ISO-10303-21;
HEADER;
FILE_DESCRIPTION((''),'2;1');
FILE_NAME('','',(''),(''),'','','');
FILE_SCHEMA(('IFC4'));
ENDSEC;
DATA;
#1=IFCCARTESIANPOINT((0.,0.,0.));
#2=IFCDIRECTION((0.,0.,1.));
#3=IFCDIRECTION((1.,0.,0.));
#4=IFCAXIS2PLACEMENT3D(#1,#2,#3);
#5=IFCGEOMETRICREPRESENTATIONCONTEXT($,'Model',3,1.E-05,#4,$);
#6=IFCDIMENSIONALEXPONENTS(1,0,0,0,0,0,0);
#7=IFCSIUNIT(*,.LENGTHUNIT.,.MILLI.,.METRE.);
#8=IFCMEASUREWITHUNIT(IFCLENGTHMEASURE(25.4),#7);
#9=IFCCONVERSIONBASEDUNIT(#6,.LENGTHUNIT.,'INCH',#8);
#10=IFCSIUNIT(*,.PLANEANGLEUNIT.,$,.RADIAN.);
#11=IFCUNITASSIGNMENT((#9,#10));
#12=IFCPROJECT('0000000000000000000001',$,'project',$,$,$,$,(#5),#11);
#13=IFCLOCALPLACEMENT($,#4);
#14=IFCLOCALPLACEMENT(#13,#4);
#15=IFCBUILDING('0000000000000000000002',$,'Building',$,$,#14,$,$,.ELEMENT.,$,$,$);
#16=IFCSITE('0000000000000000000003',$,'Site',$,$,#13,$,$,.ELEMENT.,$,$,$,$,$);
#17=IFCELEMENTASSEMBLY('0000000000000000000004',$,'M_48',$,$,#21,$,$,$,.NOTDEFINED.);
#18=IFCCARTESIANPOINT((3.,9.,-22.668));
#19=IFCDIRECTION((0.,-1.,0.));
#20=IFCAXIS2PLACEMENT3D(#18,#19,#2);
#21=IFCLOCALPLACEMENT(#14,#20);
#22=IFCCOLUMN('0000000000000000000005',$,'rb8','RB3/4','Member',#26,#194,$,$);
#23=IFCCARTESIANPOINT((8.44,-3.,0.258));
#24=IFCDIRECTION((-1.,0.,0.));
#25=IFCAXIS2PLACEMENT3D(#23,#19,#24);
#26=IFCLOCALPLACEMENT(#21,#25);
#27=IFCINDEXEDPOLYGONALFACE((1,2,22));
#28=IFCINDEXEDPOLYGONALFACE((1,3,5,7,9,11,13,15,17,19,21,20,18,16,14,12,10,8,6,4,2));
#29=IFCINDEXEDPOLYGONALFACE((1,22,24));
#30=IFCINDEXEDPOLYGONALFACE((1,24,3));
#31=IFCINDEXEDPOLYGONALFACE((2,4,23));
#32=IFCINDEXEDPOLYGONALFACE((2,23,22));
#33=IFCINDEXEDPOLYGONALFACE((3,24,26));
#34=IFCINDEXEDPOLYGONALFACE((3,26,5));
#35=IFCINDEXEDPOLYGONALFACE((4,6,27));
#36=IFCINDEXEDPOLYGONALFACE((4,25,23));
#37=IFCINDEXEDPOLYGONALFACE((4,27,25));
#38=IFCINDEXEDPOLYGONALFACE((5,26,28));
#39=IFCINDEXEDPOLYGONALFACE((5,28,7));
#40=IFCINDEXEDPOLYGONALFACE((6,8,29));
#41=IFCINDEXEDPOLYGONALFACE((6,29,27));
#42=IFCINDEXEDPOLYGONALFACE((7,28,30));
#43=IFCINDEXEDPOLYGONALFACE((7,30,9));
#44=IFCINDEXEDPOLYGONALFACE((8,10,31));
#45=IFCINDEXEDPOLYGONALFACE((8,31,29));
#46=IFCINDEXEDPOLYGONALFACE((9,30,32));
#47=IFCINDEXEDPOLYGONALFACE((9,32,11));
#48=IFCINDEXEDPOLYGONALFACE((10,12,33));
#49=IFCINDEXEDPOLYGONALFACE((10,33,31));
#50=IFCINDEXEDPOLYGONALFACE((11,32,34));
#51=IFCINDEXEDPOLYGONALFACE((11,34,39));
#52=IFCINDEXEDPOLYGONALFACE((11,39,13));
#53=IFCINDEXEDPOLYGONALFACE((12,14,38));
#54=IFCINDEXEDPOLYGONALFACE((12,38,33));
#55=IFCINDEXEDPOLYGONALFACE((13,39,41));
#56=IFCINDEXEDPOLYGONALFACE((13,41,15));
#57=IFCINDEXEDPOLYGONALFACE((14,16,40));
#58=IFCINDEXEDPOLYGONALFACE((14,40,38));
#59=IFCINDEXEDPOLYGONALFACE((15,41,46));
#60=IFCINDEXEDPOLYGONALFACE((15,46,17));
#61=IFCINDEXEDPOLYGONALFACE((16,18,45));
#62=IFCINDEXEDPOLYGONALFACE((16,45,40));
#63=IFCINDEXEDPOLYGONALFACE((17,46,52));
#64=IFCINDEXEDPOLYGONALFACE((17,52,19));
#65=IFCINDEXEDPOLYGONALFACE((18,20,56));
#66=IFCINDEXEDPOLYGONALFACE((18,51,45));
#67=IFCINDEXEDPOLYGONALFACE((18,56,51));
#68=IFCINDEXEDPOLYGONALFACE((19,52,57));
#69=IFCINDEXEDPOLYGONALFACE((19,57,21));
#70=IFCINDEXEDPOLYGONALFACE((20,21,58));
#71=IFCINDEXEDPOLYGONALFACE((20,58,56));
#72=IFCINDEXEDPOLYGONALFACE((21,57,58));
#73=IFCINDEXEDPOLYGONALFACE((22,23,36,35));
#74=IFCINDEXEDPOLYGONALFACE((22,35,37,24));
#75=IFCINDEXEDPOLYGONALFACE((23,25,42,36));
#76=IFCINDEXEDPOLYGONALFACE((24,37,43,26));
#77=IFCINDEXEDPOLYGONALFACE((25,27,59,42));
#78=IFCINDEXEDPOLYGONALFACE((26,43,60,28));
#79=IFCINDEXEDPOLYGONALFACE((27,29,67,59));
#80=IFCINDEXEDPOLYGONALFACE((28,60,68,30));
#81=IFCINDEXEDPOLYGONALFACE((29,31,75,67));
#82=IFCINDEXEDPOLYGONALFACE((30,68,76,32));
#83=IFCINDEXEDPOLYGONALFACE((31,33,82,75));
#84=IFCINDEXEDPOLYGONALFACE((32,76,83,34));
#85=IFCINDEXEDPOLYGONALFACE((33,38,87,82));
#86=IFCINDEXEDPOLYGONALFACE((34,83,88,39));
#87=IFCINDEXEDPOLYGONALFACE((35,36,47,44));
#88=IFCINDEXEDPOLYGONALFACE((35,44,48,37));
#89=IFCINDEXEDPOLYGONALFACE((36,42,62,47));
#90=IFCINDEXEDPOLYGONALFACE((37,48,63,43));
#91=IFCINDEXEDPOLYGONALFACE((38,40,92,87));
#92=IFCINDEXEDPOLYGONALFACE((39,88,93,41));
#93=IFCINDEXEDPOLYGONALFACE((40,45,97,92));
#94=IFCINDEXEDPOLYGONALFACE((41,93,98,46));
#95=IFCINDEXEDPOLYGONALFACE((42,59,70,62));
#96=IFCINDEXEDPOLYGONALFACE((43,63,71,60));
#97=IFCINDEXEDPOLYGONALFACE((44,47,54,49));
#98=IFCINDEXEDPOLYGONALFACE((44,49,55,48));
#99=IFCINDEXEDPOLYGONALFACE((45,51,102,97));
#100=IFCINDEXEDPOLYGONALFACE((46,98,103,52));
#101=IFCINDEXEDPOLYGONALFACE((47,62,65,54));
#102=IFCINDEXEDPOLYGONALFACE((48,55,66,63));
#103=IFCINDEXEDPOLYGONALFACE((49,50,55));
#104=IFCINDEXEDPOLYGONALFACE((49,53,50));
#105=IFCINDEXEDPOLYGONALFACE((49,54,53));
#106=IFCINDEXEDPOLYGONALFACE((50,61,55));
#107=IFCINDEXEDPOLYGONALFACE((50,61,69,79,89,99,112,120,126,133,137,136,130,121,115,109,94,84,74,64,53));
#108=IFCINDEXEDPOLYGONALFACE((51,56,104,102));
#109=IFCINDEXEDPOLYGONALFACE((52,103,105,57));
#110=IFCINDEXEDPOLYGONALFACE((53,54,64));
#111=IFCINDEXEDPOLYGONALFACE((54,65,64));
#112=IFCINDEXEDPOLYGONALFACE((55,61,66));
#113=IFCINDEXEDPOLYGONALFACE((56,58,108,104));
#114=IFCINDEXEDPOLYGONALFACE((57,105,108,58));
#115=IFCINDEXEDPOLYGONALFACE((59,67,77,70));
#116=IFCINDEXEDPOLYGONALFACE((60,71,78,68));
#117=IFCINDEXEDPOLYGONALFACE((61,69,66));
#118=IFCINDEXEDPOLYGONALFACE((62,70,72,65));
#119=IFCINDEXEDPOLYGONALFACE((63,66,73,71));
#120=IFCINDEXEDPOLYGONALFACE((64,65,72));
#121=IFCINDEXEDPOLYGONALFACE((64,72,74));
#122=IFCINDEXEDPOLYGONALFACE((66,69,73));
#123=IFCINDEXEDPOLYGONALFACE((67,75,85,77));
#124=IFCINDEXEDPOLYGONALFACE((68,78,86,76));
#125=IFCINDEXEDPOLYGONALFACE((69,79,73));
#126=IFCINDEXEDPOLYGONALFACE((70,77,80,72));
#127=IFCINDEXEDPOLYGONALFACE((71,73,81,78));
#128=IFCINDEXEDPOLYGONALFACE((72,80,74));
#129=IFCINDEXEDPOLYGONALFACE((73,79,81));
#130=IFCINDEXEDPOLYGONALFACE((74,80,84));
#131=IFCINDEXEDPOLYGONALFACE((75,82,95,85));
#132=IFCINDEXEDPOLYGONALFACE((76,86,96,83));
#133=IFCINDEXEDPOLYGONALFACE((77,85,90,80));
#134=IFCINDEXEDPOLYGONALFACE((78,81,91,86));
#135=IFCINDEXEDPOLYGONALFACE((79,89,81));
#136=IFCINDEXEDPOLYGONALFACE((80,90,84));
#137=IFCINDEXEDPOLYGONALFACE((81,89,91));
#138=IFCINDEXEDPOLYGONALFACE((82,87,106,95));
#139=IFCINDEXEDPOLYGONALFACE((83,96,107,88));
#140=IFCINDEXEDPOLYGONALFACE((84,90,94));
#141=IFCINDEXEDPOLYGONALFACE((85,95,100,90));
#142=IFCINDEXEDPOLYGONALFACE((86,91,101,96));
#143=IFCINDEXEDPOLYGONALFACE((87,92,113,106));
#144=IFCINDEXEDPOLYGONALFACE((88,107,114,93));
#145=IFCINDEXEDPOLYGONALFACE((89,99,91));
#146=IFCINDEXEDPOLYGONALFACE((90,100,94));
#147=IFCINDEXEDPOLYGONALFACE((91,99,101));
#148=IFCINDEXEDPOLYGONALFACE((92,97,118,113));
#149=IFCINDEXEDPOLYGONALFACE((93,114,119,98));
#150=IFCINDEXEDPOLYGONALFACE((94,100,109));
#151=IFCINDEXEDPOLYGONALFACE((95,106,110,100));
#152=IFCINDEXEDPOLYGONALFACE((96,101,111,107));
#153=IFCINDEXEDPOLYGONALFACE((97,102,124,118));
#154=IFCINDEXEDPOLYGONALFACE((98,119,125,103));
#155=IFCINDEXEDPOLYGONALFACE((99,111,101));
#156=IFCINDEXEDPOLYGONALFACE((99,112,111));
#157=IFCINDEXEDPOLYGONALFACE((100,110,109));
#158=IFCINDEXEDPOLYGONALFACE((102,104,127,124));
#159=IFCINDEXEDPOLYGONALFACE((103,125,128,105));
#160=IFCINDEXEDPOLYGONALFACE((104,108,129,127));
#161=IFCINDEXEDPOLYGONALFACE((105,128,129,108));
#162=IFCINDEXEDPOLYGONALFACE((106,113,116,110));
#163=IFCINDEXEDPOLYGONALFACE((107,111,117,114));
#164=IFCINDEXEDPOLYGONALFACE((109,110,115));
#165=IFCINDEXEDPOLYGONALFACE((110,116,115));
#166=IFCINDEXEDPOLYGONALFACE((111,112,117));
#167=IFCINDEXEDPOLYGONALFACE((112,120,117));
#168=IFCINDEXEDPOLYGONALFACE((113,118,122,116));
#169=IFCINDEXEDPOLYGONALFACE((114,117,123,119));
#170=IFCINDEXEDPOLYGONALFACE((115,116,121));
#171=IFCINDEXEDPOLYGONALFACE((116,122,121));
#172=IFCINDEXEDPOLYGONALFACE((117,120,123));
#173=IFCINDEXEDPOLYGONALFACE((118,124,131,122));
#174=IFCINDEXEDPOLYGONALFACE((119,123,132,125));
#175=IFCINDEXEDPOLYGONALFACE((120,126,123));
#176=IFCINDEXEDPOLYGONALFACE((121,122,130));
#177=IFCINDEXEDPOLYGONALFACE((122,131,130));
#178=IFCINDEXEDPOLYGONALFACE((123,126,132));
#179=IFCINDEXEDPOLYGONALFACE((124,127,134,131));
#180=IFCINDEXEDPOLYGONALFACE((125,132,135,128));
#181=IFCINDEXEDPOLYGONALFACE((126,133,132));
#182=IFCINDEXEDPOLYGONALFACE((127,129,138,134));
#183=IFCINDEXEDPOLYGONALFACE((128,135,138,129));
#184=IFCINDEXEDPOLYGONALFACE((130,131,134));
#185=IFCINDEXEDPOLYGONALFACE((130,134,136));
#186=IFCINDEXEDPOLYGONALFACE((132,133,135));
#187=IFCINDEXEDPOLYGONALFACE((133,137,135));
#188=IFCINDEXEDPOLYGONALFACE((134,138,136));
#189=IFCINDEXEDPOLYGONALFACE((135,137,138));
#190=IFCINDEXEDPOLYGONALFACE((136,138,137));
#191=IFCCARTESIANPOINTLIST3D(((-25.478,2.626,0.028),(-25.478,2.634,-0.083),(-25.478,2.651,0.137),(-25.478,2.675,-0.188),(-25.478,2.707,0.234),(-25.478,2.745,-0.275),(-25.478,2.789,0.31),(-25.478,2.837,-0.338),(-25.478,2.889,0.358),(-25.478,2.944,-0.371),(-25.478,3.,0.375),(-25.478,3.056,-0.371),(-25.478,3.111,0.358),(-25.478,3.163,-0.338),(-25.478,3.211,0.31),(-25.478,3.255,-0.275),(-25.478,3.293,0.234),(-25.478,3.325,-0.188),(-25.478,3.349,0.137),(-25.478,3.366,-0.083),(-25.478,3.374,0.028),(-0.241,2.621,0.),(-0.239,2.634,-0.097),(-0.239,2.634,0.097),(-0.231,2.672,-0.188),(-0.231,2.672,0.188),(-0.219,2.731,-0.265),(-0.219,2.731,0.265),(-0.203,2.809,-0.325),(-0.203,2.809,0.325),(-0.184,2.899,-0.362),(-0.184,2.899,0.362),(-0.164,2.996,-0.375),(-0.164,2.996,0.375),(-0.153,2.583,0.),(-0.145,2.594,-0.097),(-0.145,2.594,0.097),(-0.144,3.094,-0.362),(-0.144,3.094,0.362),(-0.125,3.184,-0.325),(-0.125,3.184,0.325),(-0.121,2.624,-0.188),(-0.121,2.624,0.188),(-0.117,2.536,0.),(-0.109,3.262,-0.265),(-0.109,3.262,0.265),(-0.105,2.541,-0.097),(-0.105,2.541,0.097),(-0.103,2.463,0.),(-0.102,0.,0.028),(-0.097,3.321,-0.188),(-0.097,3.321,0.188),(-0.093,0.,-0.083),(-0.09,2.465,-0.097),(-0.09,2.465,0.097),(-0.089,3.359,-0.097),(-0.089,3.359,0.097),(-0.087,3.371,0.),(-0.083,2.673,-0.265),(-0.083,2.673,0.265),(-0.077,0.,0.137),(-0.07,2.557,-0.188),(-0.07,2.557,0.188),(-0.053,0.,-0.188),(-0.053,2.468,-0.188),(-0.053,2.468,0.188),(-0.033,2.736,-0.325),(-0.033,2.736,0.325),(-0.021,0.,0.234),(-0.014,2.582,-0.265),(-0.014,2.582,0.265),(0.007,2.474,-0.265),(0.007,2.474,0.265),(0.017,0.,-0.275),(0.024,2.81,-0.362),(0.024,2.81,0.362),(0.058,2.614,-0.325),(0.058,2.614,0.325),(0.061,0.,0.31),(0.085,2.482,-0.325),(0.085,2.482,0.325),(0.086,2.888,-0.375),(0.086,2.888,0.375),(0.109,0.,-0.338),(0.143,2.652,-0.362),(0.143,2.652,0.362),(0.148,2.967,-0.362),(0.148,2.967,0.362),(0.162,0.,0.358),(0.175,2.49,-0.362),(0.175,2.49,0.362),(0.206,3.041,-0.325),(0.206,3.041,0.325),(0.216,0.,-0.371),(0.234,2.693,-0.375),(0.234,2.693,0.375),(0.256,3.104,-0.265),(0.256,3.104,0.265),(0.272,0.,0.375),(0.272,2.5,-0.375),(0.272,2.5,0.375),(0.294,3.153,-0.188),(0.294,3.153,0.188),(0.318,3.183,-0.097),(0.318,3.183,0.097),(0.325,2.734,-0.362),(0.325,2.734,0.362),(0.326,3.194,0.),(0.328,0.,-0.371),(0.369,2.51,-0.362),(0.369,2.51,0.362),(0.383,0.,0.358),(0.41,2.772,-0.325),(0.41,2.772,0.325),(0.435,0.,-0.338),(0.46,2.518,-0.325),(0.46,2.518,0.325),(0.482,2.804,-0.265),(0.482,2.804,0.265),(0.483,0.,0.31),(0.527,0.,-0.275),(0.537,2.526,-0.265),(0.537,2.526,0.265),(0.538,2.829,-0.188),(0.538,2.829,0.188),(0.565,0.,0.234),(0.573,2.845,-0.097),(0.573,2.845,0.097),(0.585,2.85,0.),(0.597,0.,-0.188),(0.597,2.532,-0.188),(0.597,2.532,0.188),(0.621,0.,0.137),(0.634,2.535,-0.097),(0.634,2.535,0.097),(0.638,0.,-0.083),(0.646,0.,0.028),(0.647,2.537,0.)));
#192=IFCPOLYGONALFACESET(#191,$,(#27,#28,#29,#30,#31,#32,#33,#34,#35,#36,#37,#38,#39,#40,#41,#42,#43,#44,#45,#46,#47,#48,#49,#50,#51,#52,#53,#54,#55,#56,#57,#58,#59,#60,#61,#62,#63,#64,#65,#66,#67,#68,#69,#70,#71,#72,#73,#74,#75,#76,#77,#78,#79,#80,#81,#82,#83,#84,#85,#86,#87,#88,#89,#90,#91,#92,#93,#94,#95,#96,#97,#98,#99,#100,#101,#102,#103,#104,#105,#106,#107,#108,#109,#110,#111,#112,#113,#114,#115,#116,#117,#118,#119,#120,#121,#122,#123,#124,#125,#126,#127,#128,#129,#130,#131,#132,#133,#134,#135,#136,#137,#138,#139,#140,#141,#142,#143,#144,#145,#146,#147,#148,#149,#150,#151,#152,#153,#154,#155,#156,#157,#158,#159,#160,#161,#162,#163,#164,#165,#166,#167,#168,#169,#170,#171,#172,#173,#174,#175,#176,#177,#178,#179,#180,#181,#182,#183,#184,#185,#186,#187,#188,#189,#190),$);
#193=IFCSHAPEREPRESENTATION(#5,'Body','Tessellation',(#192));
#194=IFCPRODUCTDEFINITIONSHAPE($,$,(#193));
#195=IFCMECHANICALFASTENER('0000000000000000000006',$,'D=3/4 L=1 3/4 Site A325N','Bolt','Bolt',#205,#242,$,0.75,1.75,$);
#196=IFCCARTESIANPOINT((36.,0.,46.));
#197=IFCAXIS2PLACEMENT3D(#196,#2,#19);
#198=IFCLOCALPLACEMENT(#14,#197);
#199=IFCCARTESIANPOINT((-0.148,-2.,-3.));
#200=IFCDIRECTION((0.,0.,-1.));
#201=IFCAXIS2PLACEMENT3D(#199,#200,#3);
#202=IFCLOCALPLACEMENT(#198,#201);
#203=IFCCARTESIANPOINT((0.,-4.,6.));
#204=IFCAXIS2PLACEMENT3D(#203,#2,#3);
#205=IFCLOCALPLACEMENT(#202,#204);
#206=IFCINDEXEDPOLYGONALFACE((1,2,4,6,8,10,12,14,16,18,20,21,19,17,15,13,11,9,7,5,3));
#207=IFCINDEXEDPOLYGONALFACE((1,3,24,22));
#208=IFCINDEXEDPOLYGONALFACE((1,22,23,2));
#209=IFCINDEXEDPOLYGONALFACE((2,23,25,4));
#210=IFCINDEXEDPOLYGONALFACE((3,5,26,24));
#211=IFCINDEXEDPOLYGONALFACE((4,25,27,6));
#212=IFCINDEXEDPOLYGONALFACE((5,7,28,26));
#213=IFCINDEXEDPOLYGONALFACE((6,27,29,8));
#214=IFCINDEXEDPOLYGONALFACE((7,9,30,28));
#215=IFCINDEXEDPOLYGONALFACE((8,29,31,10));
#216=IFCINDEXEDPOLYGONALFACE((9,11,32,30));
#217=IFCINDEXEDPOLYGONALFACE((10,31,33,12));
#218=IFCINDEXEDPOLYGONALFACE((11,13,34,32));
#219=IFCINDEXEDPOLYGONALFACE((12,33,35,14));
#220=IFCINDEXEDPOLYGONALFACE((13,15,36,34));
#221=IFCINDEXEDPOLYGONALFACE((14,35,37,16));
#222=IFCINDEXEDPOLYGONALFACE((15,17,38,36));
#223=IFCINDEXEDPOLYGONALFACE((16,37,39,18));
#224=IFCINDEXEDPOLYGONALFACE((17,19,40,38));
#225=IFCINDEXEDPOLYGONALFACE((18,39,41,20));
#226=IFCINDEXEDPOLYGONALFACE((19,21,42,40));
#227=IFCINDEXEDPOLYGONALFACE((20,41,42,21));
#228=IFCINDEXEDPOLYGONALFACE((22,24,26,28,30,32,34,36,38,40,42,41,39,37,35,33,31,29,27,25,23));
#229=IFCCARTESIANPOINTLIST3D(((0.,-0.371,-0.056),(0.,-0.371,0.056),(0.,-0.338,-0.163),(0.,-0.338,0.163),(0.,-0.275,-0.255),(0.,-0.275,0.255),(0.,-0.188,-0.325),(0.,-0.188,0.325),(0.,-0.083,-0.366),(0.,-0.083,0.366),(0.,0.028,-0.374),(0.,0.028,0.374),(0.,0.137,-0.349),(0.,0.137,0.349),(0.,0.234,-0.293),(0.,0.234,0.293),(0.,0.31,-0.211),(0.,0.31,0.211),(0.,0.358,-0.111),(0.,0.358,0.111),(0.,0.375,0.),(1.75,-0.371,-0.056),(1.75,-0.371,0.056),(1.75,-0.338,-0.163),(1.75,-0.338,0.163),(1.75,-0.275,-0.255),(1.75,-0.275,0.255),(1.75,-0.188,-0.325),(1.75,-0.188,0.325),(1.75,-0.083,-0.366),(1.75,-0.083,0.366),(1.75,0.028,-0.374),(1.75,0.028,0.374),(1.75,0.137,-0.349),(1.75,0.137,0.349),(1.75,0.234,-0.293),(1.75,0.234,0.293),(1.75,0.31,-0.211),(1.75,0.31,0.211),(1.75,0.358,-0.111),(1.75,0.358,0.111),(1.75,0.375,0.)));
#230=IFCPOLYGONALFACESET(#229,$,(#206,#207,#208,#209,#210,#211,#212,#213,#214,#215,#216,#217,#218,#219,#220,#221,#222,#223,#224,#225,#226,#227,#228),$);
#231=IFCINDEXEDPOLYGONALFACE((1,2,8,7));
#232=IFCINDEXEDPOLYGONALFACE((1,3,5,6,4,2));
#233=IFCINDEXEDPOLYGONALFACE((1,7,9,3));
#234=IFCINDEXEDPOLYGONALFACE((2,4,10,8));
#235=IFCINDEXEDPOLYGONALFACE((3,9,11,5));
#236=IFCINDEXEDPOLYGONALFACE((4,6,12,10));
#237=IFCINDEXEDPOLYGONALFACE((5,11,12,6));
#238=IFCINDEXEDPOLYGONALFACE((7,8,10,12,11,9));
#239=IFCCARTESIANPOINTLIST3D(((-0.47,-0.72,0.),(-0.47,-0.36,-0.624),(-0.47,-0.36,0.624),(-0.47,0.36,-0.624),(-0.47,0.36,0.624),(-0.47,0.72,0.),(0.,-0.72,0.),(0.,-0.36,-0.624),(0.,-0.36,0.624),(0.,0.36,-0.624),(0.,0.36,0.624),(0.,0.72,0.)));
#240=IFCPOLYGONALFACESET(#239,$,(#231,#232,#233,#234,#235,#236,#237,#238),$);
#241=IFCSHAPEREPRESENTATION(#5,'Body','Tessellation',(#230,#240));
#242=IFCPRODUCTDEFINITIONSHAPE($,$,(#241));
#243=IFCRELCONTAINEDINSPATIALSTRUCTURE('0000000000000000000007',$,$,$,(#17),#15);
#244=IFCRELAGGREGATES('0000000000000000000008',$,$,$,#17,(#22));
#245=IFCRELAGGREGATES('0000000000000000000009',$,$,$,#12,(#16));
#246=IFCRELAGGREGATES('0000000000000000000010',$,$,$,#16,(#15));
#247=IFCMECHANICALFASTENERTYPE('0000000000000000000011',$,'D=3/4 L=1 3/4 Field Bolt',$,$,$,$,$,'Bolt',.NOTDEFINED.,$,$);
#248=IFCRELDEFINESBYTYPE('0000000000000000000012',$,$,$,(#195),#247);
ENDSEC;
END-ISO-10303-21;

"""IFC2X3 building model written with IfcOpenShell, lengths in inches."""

from ifc_helpers import new_model, entity, si_unit, converted_unit, frame, origin_with_axes, origin_2d_with_axis, place, context, project, spatial, polyline, circle, outline, extrude, source, transform, mapped, type_object, type_shapes, element, aggregate, save


model = new_model("IFC2X3")

# Units and contexts
model_context = context("Model", 3, precision=1e-05, world=origin_with_axes())
ifc_project = project(units=[converted_unit("LENGTHUNIT", "INCH", entity("IfcLengthMeasure", 25.4), si_unit("LENGTHUNIT", "METRE", prefix="MILLI"), dimensions=[1, 0, 0, 0, 0, 0, 0]), si_unit("PLANEANGLEUNIT", "RADIAN")], contexts=[model_context])

# Site, building
site_placement = place(None, origin_with_axes())
site = spatial("IfcSite", under=ifc_project, at=site_placement, Name="Site", CompositionType="ELEMENT")
building_placement = place(site_placement, origin_with_axes())
building = spatial("IfcBuilding", under=site, at=building_placement, Name="Building", CompositionType="ELEMENT")

# Element assembly, column
assembly_1_placement = place(building_placement, frame((3.0, 9.0, -22.668), z_axis=(0.0, -1.0, 0.0), x_axis=(0.0, 0.0, 1.0)))
assembly_1 = element("IfcElementAssembly", 1, at=assembly_1_placement, inside=building, Name="M_48", PredefinedType="NOTDEFINED")
column_1_placement = place(assembly_1_placement, frame((8.44, -3.0, 0.258), z_axis=(0.0, -1.0, 0.0), x_axis=(-1.0, 0.0, 0.0)))
cartesian_point_1 = entity("IfcCartesianPoint", [0.0, 0.0, 0.0])
ifc_direction_1 = entity("IfcDirection", [0.0, 0.0, 1.0])
ifc_direction_2 = entity("IfcDirection", [1.0, 0.0, 0.0])
column_1 = element("IfcColumn", 2, at=column_1_placement, Name="rb8", Description="RB3/4", ObjectType="Member", context=model_context, shape_type="SweptSolid", body=[
    entity("IfcSurfaceCurveSweptAreaSolid", entity("IfcCircleProfileDef", "AREA", None, entity("IfcAxis2Placement2D", entity("IfcCartesianPoint", [0.0, 0.0]), entity("IfcDirection", [1.0, 0.0])), 0.375), entity("IfcAxis2Placement3D", cartesian_point_1, ifc_direction_1, ifc_direction_2), entity("IfcPolyline", [entity("IfcCartesianPoint", [0.272, 0.0]), entity("IfcCartesianPoint", [0.272, 2.5]), entity("IfcCartesianPoint", [0.234, 2.693]), entity("IfcCartesianPoint", [0.086, 2.888]), entity("IfcCartesianPoint", [-0.164, 2.996]), entity("IfcCartesianPoint", [-25.478, 3.0])]), 0.0, 1.0, entity("IfcPlane", entity("IfcAxis2Placement3D", cartesian_point_1, ifc_direction_1, ifc_direction_2))),
])
aggregate(assembly_1, [column_1])

# Mechanical fastener
mechanical_fastener_type_1 = type_object("IfcMechanicalFastenerType", Name="D=3/4 L=1 3/4 Field Bolt", ElementType="Bolt")
shared_shape_1 = source(origin_with_axes(), model_context, "Body", "SweptSolid", [
    extrude(circle(Radius=0.375, at=origin_2d_with_axis()), frame((0.0, 0.0, 0.0), z_axis=(1.0, 0.0, 0.0), x_axis=(0.0, 1.0, 0.0)), (0.0, 0.0, 1.0), 1.75),
    extrude(outline(polyline([(-0.72, 0.0), (-0.36, 0.624), (0.36, 0.624), (0.72, 0.0), (0.36, -0.624), (-0.36, -0.624), (-0.72, 0.0)])), frame((0.0, 0.0, 0.0), z_axis=(1.0, 0.0, 0.0), x_axis=(0.0, 1.0, 0.0)), (0.0, 0.0, -1.0), 0.47),
])
type_shapes(mechanical_fastener_type_1, [shared_shape_1])
placement_1 = place(building_placement, frame((36.0, 0.0, 46.0), z_axis=(0.0, 0.0, 1.0), x_axis=(0.0, -1.0, 0.0)))
placement_2 = place(placement_1, frame((-0.148, -2.0, -3.0), z_axis=(0.0, 0.0, -1.0), x_axis=(1.0, 0.0, 0.0)))
for number, where, z_axis, x_axis, name in (
    (3, (0.0, -4.0, 6.0), (0.0, 0.0, 1.0), (1.0, 0.0, 0.0), "D=3/4 L=1 3/4 Site A325N"),
):
    element("IfcMechanicalFastener", number, at=place(placement_2, frame(where, z_axis=z_axis, x_axis=x_axis)), type_object=mechanical_fastener_type_1, Name=name, Description="Bolt", ObjectType="Bolt", NominalDiameter=0.75, NominalLength=1.75, context=model_context, shape_type="MappedRepresentation", body=[
        mapped(shared_shape_1, transform((0.0, 0.0, 0.0), scale=1.0)),
    ])

save(model, "model.ifc")
